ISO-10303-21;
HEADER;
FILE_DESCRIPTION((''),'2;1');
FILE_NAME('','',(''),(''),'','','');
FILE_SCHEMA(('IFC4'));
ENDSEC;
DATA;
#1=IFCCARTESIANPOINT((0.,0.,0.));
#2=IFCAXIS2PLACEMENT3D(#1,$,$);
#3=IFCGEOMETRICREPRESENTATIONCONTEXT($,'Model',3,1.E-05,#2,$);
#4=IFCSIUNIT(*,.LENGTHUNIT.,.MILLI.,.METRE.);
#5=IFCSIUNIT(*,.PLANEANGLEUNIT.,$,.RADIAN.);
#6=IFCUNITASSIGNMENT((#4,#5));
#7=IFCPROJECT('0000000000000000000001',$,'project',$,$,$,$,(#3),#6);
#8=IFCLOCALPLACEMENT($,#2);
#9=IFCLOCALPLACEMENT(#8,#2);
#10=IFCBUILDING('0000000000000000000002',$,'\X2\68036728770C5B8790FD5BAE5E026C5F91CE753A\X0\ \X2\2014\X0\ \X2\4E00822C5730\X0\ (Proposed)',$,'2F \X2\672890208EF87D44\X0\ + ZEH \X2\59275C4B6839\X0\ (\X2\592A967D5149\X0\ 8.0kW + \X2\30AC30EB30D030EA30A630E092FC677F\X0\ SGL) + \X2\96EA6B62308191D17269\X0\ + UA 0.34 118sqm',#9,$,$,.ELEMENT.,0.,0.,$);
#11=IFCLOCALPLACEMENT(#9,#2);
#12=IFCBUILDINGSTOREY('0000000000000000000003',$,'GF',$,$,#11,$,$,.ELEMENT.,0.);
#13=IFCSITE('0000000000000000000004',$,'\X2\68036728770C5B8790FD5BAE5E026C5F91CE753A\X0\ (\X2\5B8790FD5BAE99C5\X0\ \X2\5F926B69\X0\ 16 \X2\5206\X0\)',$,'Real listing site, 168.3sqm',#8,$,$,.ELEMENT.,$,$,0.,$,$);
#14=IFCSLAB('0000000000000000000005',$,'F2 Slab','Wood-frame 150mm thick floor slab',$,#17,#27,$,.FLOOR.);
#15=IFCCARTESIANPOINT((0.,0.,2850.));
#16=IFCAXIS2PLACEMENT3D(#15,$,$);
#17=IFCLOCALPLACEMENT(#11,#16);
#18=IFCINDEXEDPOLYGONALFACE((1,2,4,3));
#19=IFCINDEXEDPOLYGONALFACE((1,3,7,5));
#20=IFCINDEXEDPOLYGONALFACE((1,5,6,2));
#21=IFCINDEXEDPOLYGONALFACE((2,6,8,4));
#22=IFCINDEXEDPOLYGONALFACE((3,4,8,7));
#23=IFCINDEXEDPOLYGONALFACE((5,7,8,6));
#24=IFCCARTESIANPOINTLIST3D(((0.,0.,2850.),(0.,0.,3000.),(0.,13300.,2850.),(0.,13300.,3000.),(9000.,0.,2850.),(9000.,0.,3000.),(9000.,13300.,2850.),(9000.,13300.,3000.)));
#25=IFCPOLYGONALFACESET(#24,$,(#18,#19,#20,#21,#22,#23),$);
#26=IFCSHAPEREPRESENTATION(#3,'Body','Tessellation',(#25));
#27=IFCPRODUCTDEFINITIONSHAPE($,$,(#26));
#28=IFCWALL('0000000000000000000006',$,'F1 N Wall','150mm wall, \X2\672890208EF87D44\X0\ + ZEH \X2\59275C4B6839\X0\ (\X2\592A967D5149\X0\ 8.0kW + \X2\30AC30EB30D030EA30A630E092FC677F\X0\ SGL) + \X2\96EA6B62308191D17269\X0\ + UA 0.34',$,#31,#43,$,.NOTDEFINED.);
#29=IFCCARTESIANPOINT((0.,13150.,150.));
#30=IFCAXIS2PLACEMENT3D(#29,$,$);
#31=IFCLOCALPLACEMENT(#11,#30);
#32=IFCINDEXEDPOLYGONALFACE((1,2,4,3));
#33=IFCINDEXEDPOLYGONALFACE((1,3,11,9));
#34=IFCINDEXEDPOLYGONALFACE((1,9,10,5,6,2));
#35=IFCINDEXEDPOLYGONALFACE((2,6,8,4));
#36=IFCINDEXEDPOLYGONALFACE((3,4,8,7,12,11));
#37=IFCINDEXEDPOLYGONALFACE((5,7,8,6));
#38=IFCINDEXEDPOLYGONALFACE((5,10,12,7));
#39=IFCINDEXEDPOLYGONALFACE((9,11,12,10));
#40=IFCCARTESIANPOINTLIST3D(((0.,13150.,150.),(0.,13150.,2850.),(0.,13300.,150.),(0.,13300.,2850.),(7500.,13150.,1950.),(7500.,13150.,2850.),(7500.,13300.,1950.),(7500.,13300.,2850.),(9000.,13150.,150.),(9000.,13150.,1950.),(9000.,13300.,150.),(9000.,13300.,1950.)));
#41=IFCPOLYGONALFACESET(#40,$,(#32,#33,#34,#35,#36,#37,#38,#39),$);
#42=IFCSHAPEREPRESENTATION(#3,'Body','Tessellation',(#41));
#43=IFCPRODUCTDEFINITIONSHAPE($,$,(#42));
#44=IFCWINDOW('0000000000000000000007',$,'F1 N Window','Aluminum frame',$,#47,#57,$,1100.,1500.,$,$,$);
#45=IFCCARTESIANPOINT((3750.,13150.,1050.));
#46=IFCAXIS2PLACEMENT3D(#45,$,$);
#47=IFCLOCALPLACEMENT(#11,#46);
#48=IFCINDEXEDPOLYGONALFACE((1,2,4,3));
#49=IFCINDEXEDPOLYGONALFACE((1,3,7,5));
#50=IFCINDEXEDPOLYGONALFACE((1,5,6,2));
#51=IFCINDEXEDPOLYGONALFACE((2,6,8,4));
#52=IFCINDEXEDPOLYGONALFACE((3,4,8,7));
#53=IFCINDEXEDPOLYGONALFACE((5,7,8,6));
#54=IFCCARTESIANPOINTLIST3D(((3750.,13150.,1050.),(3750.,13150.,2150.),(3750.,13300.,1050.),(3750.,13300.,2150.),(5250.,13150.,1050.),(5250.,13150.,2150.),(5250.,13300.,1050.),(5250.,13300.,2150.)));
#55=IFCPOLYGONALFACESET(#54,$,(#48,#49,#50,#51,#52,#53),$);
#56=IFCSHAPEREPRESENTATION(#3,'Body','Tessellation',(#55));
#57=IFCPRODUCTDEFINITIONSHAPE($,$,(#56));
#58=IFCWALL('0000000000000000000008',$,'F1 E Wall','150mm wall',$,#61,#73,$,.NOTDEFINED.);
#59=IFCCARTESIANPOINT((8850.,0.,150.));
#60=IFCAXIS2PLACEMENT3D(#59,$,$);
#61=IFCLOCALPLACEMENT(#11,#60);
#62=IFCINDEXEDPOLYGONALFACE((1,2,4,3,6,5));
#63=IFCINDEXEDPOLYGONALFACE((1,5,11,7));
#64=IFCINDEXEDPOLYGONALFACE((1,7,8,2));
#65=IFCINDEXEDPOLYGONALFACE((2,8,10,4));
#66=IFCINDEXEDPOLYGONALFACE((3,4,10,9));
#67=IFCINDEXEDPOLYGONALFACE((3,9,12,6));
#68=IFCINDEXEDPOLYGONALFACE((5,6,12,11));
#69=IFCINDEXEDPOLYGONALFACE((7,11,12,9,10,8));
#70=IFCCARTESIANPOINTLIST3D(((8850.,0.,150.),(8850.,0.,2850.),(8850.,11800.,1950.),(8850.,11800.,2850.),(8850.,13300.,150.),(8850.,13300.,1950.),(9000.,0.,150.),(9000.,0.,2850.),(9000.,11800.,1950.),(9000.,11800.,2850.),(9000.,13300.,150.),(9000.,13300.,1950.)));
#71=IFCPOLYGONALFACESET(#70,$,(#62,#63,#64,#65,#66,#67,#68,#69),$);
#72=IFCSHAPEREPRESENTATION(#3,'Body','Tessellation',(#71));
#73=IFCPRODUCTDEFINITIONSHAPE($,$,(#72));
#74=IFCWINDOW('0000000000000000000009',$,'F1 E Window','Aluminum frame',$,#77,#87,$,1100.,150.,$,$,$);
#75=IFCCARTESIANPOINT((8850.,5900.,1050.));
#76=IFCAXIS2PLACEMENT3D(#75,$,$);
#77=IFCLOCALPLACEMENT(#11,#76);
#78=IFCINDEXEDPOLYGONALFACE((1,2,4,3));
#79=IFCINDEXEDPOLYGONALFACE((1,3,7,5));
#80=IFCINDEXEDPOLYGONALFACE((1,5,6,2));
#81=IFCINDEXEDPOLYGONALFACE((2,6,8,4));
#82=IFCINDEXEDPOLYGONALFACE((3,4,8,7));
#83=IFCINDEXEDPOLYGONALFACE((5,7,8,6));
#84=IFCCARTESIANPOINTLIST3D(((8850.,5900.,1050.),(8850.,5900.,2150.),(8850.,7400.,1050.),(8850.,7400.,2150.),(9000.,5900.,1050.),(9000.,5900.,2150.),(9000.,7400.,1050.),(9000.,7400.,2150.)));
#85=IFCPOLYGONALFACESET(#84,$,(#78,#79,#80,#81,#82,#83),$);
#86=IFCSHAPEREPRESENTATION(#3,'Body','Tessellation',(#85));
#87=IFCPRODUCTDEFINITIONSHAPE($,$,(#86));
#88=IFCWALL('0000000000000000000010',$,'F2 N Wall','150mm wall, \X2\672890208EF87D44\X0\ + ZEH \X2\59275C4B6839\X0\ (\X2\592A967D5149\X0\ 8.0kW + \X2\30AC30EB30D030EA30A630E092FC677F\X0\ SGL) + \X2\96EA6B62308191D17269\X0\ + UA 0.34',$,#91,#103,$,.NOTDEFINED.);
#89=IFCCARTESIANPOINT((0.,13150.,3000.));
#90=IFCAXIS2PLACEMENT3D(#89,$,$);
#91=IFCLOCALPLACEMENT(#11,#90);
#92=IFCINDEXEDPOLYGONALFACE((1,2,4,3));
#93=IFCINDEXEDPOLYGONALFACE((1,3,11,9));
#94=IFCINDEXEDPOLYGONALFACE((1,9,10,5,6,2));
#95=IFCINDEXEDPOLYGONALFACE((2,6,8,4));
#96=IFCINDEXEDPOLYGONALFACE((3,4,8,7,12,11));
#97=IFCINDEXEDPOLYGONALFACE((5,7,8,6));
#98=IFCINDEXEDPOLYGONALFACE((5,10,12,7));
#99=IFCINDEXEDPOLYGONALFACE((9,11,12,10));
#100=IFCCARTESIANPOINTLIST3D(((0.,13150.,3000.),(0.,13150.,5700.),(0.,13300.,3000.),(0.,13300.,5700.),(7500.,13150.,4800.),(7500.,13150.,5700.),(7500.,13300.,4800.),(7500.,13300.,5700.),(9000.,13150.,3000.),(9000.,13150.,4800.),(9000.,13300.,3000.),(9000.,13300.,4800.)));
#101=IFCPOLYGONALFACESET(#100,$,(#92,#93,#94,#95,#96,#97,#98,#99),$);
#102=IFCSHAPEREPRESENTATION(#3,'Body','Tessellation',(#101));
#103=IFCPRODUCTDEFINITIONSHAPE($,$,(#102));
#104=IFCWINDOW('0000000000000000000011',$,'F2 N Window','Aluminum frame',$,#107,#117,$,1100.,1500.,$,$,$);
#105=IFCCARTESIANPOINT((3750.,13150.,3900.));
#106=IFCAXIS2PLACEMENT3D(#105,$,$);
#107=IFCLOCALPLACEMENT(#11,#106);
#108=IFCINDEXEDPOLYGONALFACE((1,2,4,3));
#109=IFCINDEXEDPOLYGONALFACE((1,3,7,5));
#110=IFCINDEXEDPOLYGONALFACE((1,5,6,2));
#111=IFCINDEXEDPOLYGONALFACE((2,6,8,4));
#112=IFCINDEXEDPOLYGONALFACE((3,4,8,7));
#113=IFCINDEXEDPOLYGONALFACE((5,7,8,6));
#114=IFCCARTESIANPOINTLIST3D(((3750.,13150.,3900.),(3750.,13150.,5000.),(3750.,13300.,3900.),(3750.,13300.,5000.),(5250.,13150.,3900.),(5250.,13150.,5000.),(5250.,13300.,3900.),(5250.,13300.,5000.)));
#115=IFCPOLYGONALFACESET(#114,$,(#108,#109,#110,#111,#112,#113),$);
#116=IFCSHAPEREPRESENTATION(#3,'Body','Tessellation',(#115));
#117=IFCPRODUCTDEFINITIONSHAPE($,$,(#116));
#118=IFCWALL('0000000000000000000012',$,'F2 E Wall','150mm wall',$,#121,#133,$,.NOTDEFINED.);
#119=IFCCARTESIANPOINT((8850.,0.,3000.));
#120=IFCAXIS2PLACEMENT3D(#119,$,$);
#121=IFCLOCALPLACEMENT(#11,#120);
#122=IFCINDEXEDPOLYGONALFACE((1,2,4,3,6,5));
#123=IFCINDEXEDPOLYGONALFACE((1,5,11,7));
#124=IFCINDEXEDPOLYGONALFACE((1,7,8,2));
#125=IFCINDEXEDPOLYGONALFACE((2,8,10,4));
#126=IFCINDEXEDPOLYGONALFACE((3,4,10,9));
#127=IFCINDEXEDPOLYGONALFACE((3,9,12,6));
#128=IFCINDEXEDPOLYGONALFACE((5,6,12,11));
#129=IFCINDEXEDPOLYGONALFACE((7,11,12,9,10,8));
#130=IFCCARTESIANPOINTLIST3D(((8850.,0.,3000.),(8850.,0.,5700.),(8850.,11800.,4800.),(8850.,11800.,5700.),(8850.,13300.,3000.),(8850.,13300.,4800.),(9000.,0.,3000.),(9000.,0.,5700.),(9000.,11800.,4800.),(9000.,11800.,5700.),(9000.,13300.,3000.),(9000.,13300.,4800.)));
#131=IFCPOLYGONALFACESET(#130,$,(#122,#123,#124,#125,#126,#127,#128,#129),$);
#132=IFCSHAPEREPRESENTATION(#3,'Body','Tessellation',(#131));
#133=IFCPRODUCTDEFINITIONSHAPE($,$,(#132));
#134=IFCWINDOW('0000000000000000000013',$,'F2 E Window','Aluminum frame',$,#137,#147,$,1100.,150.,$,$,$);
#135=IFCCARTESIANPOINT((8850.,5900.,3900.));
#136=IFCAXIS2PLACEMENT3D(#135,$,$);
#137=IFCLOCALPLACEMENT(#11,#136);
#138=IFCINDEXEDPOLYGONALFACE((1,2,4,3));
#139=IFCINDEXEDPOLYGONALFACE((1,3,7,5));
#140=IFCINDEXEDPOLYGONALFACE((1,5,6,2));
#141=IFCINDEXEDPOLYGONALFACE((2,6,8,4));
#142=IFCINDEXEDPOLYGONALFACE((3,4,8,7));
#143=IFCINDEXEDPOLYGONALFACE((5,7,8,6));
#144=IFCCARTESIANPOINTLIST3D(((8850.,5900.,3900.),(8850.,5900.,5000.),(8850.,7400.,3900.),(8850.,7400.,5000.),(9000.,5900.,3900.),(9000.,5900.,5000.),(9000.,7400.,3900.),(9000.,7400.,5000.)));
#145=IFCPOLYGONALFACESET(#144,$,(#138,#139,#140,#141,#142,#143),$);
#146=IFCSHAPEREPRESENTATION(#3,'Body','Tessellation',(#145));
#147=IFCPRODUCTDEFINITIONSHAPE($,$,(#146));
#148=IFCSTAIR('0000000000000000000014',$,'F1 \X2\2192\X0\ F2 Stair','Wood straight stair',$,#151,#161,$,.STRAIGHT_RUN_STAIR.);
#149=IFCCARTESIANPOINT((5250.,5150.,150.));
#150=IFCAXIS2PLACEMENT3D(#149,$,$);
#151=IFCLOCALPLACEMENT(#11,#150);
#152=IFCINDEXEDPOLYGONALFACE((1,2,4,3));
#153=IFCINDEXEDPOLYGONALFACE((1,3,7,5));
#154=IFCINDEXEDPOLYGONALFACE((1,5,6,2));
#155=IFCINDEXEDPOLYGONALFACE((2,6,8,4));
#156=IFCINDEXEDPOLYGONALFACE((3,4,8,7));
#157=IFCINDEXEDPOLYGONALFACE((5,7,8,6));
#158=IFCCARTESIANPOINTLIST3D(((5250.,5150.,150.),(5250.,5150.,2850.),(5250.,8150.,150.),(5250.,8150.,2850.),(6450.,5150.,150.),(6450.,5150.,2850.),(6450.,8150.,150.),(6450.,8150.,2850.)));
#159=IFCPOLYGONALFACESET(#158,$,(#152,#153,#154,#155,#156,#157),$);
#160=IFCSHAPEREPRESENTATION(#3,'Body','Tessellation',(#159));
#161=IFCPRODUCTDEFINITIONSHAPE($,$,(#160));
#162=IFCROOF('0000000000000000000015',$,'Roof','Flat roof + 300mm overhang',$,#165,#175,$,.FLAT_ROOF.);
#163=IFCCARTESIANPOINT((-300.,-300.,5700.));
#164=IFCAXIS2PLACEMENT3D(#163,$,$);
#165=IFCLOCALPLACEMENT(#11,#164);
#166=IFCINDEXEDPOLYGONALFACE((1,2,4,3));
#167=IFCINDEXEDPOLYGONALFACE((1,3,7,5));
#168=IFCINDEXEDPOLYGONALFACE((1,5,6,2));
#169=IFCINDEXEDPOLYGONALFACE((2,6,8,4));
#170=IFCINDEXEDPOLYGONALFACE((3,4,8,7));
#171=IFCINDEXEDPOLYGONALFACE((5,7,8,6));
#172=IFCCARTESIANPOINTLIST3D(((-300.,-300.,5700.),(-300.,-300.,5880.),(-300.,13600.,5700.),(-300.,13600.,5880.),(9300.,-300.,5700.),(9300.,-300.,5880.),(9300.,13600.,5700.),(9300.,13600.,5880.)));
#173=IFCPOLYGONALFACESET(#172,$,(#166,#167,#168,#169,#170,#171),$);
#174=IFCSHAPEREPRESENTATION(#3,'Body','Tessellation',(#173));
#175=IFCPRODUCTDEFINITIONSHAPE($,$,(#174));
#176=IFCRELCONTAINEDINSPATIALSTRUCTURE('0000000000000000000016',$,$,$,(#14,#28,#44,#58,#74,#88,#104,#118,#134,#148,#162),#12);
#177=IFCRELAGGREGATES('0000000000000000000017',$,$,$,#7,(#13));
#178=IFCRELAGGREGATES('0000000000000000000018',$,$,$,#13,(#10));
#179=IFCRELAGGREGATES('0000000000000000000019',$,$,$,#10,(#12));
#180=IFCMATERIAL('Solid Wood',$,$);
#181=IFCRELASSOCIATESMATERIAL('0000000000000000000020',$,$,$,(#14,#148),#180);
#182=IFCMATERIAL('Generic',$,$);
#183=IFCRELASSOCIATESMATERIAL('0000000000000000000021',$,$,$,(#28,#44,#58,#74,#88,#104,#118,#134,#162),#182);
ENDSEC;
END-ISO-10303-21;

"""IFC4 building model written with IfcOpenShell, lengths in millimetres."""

from ifc_helpers import new_model, si_unit, frame, frame_2d, origin, place, context, project, spatial, rectangle, extrude, material, element, fill, save


model = new_model("IFC4")

# Units and contexts
model_context = context("Model", 3, precision=1e-05, world=origin())
ifc_project = project(units=[si_unit("LENGTHUNIT", "METRE", prefix="MILLI"), si_unit("PLANEANGLEUNIT", "RADIAN")], contexts=[model_context])

# Site, building, storey
site_placement = place(None, origin())
site = spatial("IfcSite", under=ifc_project, at=site_placement, Name="栃木県宇都宮市江野町 (宇都宮駅 徒歩 16 分)", ObjectType="Real listing site, 168.3sqm", CompositionType="ELEMENT", RefElevation=0.0)
building_placement = place(site_placement, origin())
building = spatial("IfcBuilding", under=site, at=building_placement, Name="栃木県宇都宮市江野町 — 一般地 (Proposed)", ObjectType="2F 木造軸組 + ZEH 大屋根 (太陽光 8.0kW + ガルバリウム鋼板 SGL) + 雪止め金物 + UA 0.34 118sqm", CompositionType="ELEMENT", ElevationOfRefHeight=0.0, ElevationOfTerrain=0.0)
storey_placement = place(building_placement, origin())
storey = spatial("IfcBuildingStorey", under=building, at=storey_placement, Name="GF", CompositionType="ELEMENT", Elevation=0.0)

# Slab
ifc_material_1 = material(Name="Solid Wood")
slab_1_placement = place(storey_placement, frame((0.0, 0.0, 2850.0)))
element("IfcSlab", 1, at=slab_1_placement, inside=storey, material=ifc_material_1, Name="F2 Slab", Description="Wood-frame 150mm thick floor slab", PredefinedType="FLOOR", context=model_context, shape_type="SweptSolid", body=[
    extrude(rectangle(XDim=9000.0, YDim=13300.0, at=frame_2d((4500.0, 6650.0))), frame((0.0, 0.0, 2850.0)), (0.0, 0.0, 1.0), 150.0),
])

# Wall, opening, window
ifc_material_2 = material(Name="Generic")
wall_1_placement = place(storey_placement, frame((0.0, 13150.0, 150.0)))
wall_1 = element("IfcWall", 2, at=wall_1_placement, inside=storey, material=ifc_material_2, Name="F1 N Wall", Description="150mm wall, 木造軸組 + ZEH 大屋根 (太陽光 8.0kW + ガルバリウム鋼板 SGL) + 雪止め金物 + UA 0.34", PredefinedType="NOTDEFINED", context=model_context, shape_type="SweptSolid", body=[
    extrude(rectangle(XDim=9000.0, YDim=150.0, at=frame_2d((4500.0, 75.0))), frame((0.0, 13150.0, 150.0)), (0.0, 0.0, 1.0), 2700.0),
])
opening_1_placement = place(storey_placement, frame((3750.0, 13150.0, 1050.0)))
opening_1 = element("IfcOpeningElement", 3, at=opening_1_placement, cuts=wall_1, PredefinedType="NOTDEFINED", context=model_context, shape_type="SweptSolid", body=[
    extrude(rectangle(XDim=1500.0, YDim=150.0, at=frame_2d((750.0, 75.0))), frame((3750.0, 13150.0, 1050.0)), (0.0, 0.0, 1.0), 1100.0),
])
window_1_placement = place(storey_placement, frame((3750.0, 13150.0, 1050.0)))
window_1 = element("IfcWindow", 4, at=window_1_placement, inside=storey, material=ifc_material_2, Name="F1 N Window", Description="Aluminum frame", OverallHeight=1100.0, OverallWidth=1500.0, context=model_context, shape_type="SweptSolid", body=[
    extrude(rectangle(XDim=1500.0, YDim=150.0, at=frame_2d((750.0, 75.0))), frame((3750.0, 13150.0, 1050.0)), (0.0, 0.0, 1.0), 1100.0),
])
fill(opening_1, window_1)

# Walls, openings, windows
wall_2_placement = place(storey_placement, frame((8850.0, 0.0, 150.0)))
wall_2 = element("IfcWall", 5, at=wall_2_placement, inside=storey, material=ifc_material_2, Name="F1 E Wall", Description="150mm wall", PredefinedType="NOTDEFINED", context=model_context, shape_type="SweptSolid", body=[
    extrude(rectangle(XDim=150.0, YDim=13300.0, at=frame_2d((75.0, 6650.0))), frame((8850.0, 0.0, 150.0)), (0.0, 0.0, 1.0), 2700.0),
])
opening_2_placement = place(storey_placement, frame((8850.0, 5900.0, 1050.0)))
opening_2 = element("IfcOpeningElement", 6, at=opening_2_placement, cuts=wall_2, PredefinedType="NOTDEFINED", context=model_context, shape_type="SweptSolid", body=[
    extrude(rectangle(XDim=150.0, YDim=1500.0, at=frame_2d((75.0, 750.0))), frame((8850.0, 5900.0, 1050.0)), (0.0, 0.0, 1.0), 1100.0),
])
window_2_placement = place(storey_placement, frame((8850.0, 5900.0, 1050.0)))
window_2 = element("IfcWindow", 7, at=window_2_placement, inside=storey, material=ifc_material_2, Name="F1 E Window", Description="Aluminum frame", OverallHeight=1100.0, OverallWidth=150.0, context=model_context, shape_type="SweptSolid", body=[
    extrude(rectangle(XDim=150.0, YDim=1500.0, at=frame_2d((75.0, 750.0))), frame((8850.0, 5900.0, 1050.0)), (0.0, 0.0, 1.0), 1100.0),
])
fill(opening_2, window_2)
wall_3_placement = place(storey_placement, frame((0.0, 13150.0, 3000.0)))
wall_3 = element("IfcWall", 8, at=wall_3_placement, inside=storey, material=ifc_material_2, Name="F2 N Wall", Description="150mm wall, 木造軸組 + ZEH 大屋根 (太陽光 8.0kW + ガルバリウム鋼板 SGL) + 雪止め金物 + UA 0.34", PredefinedType="NOTDEFINED", context=model_context, shape_type="SweptSolid", body=[
    extrude(rectangle(XDim=9000.0, YDim=150.0, at=frame_2d((4500.0, 75.0))), frame((0.0, 13150.0, 3000.0)), (0.0, 0.0, 1.0), 2700.0),
])
opening_3_placement = place(storey_placement, frame((3750.0, 13150.0, 3900.0)))
opening_3 = element("IfcOpeningElement", 9, at=opening_3_placement, cuts=wall_3, PredefinedType="NOTDEFINED", context=model_context, shape_type="SweptSolid", body=[
    extrude(rectangle(XDim=1500.0, YDim=150.0, at=frame_2d((750.0, 75.0))), frame((3750.0, 13150.0, 3900.0)), (0.0, 0.0, 1.0), 1100.0),
])
window_3_placement = place(storey_placement, frame((3750.0, 13150.0, 3900.0)))
window_3 = element("IfcWindow", 10, at=window_3_placement, inside=storey, material=ifc_material_2, Name="F2 N Window", Description="Aluminum frame", OverallHeight=1100.0, OverallWidth=1500.0, context=model_context, shape_type="SweptSolid", body=[
    extrude(rectangle(XDim=1500.0, YDim=150.0, at=frame_2d((750.0, 75.0))), frame((3750.0, 13150.0, 3900.0)), (0.0, 0.0, 1.0), 1100.0),
])
fill(opening_3, window_3)
wall_4_placement = place(storey_placement, frame((8850.0, 0.0, 3000.0)))
wall_4 = element("IfcWall", 11, at=wall_4_placement, inside=storey, material=ifc_material_2, Name="F2 E Wall", Description="150mm wall", PredefinedType="NOTDEFINED", context=model_context, shape_type="SweptSolid", body=[
    extrude(rectangle(XDim=150.0, YDim=13300.0, at=frame_2d((75.0, 6650.0))), frame((8850.0, 0.0, 3000.0)), (0.0, 0.0, 1.0), 2700.0),
])
opening_4_placement = place(storey_placement, frame((8850.0, 5900.0, 3900.0)))
opening_4 = element("IfcOpeningElement", 12, at=opening_4_placement, cuts=wall_4, PredefinedType="NOTDEFINED", context=model_context, shape_type="SweptSolid", body=[
    extrude(rectangle(XDim=150.0, YDim=1500.0, at=frame_2d((75.0, 750.0))), frame((8850.0, 5900.0, 3900.0)), (0.0, 0.0, 1.0), 1100.0),
])
window_4_placement = place(storey_placement, frame((8850.0, 5900.0, 3900.0)))
window_4 = element("IfcWindow", 13, at=window_4_placement, inside=storey, material=ifc_material_2, Name="F2 E Window", Description="Aluminum frame", OverallHeight=1100.0, OverallWidth=150.0, context=model_context, shape_type="SweptSolid", body=[
    extrude(rectangle(XDim=150.0, YDim=1500.0, at=frame_2d((75.0, 750.0))), frame((8850.0, 5900.0, 3900.0)), (0.0, 0.0, 1.0), 1100.0),
])
fill(opening_4, window_4)

# Stair
stair_placement = place(storey_placement, frame((5250.0, 5150.0, 150.0)))
element("IfcStair", 14, at=stair_placement, inside=storey, material=ifc_material_1, Name="F1 → F2 Stair", Description="Wood straight stair", PredefinedType="STRAIGHT_RUN_STAIR", context=model_context, shape_type="SweptSolid", body=[
    extrude(rectangle(XDim=1200.0, YDim=3000.0, at=frame_2d((600.0, 1500.0))), frame((5250.0, 5150.0, 150.0)), (0.0, 0.0, 1.0), 2700.0),
])

# Roof
roof_placement = place(storey_placement, frame((-300.0, -300.0, 5700.0)))
element("IfcRoof", 15, at=roof_placement, inside=storey, material=ifc_material_2, Name="Roof", Description="Flat roof + 300mm overhang", PredefinedType="FLAT_ROOF", context=model_context, shape_type="SweptSolid", body=[
    extrude(rectangle(XDim=9600.0, YDim=13900.0, at=frame_2d((4800.0, 6950.0))), frame((-300.0, -300.0, 5700.0)), (0.0, 0.0, 1.0), 180.0),
])

save(model, "model.ifc")
